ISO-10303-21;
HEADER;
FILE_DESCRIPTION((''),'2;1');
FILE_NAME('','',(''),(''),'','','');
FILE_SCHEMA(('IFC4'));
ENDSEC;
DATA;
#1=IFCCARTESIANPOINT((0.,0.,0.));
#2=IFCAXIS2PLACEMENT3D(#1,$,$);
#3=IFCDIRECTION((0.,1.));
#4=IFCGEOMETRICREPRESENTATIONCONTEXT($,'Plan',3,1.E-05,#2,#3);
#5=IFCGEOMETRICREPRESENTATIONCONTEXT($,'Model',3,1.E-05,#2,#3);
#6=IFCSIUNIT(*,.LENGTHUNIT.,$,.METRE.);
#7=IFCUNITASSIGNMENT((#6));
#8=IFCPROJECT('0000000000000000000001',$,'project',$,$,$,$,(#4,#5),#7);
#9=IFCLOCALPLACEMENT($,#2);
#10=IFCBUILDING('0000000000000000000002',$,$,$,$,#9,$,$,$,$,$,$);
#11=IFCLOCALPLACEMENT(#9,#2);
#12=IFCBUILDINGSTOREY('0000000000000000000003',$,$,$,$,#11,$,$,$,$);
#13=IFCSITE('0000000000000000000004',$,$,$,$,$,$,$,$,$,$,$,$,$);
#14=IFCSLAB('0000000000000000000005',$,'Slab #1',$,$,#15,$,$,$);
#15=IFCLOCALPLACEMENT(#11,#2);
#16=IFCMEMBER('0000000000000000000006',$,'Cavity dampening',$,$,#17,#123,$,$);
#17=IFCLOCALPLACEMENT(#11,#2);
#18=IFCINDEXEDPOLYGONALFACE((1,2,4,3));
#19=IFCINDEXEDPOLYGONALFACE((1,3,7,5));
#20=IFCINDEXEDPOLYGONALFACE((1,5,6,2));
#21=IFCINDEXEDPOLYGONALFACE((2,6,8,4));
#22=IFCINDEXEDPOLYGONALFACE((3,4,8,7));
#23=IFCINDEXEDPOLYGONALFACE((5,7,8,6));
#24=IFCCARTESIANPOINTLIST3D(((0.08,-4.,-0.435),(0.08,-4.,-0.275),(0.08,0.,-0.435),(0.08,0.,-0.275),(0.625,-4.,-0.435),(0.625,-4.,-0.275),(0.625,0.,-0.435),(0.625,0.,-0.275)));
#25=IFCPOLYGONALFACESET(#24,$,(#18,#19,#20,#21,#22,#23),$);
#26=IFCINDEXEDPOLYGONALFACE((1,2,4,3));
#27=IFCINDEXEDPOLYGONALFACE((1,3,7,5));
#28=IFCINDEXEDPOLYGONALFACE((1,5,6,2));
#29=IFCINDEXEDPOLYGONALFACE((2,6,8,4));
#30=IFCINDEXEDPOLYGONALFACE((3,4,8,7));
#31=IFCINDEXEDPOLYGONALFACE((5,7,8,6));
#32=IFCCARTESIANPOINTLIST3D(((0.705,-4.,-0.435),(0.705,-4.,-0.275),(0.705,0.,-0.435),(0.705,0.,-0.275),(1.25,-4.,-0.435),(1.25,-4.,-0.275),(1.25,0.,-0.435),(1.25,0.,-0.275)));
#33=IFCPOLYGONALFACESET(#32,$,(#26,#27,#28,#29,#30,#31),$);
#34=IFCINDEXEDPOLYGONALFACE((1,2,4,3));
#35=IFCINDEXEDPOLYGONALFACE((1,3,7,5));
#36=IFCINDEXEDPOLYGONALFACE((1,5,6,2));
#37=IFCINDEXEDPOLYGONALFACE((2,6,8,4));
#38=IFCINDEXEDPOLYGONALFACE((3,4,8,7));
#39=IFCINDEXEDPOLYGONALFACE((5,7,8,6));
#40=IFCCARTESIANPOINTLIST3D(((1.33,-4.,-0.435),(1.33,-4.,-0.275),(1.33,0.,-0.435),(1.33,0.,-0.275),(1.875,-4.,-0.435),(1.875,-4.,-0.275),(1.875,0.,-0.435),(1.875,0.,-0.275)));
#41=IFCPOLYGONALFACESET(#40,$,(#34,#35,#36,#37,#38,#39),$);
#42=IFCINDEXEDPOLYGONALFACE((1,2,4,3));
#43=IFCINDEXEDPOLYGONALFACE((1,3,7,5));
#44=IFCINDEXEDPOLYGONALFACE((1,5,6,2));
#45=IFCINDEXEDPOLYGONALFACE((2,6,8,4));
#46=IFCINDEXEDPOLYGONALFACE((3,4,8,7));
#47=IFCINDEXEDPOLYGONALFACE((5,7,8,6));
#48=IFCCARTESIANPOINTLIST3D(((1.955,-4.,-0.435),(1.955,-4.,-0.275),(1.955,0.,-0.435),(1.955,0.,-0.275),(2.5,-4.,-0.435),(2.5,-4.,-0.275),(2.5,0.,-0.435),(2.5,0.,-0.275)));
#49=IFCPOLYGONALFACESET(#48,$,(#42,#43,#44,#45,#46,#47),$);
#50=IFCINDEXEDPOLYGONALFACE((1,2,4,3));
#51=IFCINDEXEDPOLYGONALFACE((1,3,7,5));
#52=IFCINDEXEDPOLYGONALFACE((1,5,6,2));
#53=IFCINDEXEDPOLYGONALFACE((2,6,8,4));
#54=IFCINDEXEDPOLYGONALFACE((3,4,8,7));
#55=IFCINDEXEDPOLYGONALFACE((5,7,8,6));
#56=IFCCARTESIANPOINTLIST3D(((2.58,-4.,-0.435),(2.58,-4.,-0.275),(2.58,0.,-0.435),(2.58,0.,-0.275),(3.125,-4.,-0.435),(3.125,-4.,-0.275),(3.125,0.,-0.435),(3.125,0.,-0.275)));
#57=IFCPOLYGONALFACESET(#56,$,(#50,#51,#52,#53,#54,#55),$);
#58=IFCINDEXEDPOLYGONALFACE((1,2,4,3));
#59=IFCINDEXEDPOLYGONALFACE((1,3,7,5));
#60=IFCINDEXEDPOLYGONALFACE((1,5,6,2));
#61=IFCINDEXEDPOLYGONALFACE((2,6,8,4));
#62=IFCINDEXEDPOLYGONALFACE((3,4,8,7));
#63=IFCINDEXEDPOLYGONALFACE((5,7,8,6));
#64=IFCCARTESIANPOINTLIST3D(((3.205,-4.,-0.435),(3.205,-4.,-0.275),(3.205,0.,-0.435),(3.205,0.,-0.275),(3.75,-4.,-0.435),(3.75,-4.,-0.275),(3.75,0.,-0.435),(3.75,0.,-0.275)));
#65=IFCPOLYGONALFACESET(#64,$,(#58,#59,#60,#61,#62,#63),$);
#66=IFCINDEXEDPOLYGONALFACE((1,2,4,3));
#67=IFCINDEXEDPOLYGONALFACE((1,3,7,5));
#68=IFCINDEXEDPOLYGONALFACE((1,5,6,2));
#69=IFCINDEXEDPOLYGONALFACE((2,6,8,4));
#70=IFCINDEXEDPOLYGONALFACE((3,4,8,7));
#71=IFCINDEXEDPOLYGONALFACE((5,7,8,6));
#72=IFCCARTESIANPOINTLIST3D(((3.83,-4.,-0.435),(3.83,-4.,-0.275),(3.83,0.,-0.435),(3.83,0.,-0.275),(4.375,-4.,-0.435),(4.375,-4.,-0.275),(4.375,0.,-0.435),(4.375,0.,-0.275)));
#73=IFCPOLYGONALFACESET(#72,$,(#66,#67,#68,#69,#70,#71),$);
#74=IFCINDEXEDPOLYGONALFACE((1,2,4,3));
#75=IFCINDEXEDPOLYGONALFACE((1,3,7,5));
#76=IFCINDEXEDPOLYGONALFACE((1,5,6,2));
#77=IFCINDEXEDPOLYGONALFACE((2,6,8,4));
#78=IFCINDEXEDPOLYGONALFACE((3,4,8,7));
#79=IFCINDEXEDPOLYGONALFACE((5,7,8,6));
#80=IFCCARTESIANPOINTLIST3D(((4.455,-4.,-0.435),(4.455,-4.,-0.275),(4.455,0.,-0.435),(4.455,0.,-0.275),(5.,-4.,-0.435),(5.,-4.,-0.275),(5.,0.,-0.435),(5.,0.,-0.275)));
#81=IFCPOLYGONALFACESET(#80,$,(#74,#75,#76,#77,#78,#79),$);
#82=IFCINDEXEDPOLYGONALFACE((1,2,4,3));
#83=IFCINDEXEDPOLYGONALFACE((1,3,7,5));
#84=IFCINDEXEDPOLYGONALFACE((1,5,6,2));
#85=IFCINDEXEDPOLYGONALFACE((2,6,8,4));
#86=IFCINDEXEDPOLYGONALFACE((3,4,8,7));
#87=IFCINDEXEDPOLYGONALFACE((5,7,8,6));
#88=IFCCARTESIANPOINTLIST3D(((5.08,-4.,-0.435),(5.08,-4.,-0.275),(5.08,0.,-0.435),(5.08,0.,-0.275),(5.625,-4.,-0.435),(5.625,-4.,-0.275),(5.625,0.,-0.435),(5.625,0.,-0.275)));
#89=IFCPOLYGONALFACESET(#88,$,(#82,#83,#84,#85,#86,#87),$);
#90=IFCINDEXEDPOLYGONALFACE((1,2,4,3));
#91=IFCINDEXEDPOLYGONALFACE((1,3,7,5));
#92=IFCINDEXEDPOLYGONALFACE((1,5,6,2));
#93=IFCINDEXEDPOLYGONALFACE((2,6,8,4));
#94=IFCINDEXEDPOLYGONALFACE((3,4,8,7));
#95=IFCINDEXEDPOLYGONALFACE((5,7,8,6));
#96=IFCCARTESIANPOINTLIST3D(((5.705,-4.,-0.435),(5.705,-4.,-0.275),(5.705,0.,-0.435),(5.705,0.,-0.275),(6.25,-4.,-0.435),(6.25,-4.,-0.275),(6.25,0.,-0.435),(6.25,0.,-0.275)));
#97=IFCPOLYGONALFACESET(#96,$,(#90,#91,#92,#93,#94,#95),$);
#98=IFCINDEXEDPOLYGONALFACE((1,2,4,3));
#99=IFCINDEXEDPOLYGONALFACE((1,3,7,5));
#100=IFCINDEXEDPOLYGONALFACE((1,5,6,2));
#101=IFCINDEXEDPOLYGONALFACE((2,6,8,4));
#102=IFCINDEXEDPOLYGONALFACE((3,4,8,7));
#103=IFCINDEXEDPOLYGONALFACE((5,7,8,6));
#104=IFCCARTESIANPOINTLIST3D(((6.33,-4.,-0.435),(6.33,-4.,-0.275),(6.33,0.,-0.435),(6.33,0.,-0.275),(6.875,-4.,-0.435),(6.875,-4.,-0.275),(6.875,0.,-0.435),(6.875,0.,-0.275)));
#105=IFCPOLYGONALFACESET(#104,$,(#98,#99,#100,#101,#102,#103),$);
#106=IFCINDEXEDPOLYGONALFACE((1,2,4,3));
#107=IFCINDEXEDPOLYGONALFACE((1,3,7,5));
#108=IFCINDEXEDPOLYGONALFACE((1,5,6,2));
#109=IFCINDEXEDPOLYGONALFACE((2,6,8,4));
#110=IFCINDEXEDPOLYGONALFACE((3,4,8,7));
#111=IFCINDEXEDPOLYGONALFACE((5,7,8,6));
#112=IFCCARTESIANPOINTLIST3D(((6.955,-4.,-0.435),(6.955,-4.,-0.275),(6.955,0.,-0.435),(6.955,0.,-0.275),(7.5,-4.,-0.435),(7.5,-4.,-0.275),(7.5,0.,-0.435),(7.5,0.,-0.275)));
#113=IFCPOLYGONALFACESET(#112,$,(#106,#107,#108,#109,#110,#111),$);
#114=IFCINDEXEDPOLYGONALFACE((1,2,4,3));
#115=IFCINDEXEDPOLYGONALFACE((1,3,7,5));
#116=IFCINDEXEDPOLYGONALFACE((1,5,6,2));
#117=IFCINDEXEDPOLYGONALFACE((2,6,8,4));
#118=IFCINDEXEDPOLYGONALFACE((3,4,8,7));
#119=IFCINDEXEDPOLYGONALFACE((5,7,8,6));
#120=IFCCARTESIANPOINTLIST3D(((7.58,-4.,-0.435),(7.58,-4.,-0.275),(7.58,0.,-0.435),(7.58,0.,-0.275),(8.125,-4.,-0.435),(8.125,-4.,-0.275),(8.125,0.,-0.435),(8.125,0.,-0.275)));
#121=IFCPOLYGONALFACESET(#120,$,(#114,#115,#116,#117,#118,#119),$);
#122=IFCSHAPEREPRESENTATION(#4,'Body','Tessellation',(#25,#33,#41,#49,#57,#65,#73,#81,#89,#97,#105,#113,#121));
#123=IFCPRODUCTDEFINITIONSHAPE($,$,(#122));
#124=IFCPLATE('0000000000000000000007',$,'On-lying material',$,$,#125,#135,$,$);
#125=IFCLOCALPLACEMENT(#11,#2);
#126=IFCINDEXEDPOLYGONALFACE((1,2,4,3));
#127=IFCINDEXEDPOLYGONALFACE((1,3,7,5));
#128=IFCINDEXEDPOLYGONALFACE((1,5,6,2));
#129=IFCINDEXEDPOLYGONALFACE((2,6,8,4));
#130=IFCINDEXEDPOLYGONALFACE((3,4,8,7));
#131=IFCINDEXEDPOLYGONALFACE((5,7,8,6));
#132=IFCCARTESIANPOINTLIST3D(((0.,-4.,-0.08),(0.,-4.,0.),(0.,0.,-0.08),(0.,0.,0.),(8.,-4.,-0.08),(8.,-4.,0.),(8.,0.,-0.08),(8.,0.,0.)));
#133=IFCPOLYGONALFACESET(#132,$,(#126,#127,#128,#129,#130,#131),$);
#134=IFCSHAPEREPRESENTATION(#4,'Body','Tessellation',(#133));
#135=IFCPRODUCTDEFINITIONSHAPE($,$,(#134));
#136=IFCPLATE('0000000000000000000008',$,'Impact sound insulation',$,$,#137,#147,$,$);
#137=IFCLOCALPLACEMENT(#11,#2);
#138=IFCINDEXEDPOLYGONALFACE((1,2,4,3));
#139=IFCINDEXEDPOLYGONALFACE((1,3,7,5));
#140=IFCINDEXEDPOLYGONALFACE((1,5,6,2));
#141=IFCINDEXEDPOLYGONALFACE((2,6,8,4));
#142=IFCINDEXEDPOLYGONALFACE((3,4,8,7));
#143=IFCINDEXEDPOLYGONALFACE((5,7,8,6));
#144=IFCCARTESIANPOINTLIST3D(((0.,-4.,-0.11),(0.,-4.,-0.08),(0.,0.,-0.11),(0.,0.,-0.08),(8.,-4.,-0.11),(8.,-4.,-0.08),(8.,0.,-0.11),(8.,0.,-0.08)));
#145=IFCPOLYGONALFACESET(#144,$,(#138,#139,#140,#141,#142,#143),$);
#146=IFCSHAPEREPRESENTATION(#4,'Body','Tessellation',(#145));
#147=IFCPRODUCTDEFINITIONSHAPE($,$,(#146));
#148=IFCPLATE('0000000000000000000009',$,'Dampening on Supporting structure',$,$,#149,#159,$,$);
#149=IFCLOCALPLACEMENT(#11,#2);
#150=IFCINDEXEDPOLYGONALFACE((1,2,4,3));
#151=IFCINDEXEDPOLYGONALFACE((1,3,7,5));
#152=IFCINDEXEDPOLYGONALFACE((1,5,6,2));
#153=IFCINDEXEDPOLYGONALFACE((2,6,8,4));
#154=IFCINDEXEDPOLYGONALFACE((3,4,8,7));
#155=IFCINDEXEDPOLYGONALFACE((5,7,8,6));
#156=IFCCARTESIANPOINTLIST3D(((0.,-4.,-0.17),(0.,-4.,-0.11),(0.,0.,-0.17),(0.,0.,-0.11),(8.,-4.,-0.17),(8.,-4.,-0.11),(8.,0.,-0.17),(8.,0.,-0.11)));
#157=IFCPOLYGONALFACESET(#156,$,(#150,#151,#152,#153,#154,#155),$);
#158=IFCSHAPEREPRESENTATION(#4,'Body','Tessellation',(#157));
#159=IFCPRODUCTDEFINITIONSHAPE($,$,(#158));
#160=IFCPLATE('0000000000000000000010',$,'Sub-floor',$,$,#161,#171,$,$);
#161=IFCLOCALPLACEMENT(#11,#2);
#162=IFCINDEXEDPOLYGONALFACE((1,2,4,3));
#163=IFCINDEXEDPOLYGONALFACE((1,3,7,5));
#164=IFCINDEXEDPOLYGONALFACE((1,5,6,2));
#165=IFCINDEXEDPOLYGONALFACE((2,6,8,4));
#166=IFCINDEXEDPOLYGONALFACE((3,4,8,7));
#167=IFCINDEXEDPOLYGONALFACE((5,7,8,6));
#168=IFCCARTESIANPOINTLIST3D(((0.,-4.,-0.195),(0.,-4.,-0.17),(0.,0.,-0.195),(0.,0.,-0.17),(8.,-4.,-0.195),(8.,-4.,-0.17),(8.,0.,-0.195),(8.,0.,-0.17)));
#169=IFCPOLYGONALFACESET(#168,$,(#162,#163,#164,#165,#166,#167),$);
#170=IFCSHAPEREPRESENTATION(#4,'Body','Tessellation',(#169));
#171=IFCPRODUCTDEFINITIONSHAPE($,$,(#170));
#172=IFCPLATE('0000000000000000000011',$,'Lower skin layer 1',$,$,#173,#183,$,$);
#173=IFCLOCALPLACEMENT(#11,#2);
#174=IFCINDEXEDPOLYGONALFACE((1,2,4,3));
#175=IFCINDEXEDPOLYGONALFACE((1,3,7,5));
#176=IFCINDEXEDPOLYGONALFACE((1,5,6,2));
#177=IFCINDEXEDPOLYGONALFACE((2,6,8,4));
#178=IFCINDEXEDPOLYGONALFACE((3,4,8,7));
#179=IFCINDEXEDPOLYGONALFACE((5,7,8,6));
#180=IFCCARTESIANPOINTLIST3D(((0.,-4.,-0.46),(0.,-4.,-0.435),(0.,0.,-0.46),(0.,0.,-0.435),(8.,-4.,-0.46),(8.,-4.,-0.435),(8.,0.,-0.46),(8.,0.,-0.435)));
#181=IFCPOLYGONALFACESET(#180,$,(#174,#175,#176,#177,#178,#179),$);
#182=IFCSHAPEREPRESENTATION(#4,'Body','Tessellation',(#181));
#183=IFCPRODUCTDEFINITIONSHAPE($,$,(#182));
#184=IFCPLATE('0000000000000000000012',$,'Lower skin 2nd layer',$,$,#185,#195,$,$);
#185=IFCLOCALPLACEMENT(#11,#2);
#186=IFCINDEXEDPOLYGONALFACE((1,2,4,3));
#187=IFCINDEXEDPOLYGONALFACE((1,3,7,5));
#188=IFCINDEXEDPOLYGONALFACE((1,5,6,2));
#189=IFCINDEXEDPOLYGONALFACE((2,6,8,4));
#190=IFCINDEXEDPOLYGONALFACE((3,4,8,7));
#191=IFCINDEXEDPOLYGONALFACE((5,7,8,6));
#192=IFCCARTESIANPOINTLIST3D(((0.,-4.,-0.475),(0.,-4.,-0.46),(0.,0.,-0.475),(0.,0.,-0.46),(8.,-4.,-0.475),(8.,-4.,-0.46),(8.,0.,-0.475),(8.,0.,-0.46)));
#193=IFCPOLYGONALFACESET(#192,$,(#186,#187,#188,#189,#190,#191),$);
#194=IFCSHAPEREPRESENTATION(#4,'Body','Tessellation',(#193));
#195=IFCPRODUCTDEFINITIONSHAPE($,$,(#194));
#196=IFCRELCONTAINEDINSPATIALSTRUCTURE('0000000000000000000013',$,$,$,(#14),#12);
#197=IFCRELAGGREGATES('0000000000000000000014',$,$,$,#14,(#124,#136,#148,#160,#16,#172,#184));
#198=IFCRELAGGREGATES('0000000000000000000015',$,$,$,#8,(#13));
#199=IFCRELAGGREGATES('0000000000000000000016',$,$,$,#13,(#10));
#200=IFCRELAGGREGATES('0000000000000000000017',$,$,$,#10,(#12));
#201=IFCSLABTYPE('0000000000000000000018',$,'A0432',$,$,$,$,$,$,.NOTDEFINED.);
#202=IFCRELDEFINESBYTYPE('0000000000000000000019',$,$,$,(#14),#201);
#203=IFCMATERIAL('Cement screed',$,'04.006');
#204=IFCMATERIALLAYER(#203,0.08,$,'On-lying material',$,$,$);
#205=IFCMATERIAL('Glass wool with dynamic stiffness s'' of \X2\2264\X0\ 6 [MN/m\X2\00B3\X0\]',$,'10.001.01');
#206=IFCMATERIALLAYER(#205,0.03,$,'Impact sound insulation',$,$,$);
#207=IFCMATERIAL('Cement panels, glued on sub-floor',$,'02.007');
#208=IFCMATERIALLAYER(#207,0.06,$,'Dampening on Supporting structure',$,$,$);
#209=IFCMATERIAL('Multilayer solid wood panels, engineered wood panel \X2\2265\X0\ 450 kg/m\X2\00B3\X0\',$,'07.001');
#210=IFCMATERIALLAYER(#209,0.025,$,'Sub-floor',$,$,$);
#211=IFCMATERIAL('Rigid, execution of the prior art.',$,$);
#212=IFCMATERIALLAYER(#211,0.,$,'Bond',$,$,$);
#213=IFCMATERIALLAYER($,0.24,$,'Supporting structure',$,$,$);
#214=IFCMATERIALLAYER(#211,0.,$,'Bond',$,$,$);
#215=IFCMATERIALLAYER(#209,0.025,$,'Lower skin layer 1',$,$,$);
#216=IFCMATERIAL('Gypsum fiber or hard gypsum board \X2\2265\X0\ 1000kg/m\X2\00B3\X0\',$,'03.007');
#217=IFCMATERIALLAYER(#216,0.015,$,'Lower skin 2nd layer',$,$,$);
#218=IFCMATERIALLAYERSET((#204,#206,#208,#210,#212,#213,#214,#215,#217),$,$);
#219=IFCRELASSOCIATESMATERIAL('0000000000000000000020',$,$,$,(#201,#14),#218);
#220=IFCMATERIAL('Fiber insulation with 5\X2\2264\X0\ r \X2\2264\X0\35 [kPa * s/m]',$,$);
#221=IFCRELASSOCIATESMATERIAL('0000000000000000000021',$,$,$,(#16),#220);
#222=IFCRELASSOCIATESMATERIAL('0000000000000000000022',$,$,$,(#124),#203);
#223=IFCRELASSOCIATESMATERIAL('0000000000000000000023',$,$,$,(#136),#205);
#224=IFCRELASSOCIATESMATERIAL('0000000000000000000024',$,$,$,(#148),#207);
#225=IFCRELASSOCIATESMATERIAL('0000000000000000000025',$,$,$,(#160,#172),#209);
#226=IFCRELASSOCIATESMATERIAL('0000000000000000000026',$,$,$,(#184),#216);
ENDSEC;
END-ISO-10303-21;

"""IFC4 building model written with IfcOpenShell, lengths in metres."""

from ifc_helpers import new_model, si_unit, direction, frame, frame_2d, origin, origin_with_axes, place, context, project, spatial, rectangle, extrude, material, layer, layer_set, type_object, element, aggregate, save


model = new_model("IFC4")

# Units and contexts
plan_context = context("Plan", 3, precision=1e-05, world=origin(), true_north=direction((0.0, 1.0)))
model_context = context("Model", 3, precision=1e-05, world=origin(), true_north=direction((0.0, 1.0)))
ifc_project = project(units=[si_unit("LENGTHUNIT", "METRE")], contexts=[plan_context, model_context])

# Site, building, storey
site = spatial("IfcSite", under=ifc_project)
building_placement = place(None, origin())
building = spatial("IfcBuilding", under=site, at=building_placement)
storey_placement = place(building_placement, origin())
storey = spatial("IfcBuildingStorey", under=building, at=storey_placement)

# Slab, member, plates
ifc_material_1 = material(Name="Cement screed", Category="04.006")
ifc_layer_1 = layer(ifc_material_1, 0.08, Name="On-lying material")
ifc_material_2 = material(Name="Glass wool with dynamic stiffness s' of ≤ 6 [MN/m³]", Category="10.001.01")
ifc_layer_2 = layer(ifc_material_2, 0.03, Name="Impact sound insulation")
ifc_material_3 = material(Name="Cement panels, glued on sub-floor", Category="02.007")
ifc_layer_3 = layer(ifc_material_3, 0.06, Name="Dampening on Supporting structure")
ifc_material_4 = material(Name="Multilayer solid wood panels, engineered wood panel ≥ 450 kg/m³", Category="07.001")
ifc_layer_4 = layer(ifc_material_4, 0.025, Name="Sub-floor")
ifc_material_5 = material(Name="Rigid, execution of the prior art.")
ifc_layer_5 = layer(ifc_material_5, 0.0, Name="Bond")
ifc_layer_6 = layer(None, 0.24, Name="Supporting structure")
ifc_layer_7 = layer(ifc_material_5, 0.0, Name="Bond")
ifc_layer_8 = layer(ifc_material_4, 0.025, Name="Lower skin layer 1")
ifc_material_6 = material(Name="Gypsum fiber or hard gypsum board ≥ 1000kg/m³", Category="03.007")
ifc_layer_9 = layer(ifc_material_6, 0.015, Name="Lower skin 2nd layer")
ifc_layer_set = layer_set([ifc_layer_1, ifc_layer_2, ifc_layer_3, ifc_layer_4, ifc_layer_5, ifc_layer_6, ifc_layer_7, ifc_layer_8, ifc_layer_9])
slab_type = type_object("IfcSlabType", Name="A0432", PredefinedType="NOTDEFINED", material=ifc_layer_set)
slab_placement = place(None, frame((0.0, 0.0, 0.0), z_axis=(0.0, 0.0, -1.0), x_axis=(1.0, 0.0, 0.0)))
slab = element("IfcSlab", 1, at=slab_placement, inside=storey, type_object=slab_type, material=ifc_layer_set, Name="Slab #1")
ifc_material_7 = material(Name="Fiber insulation with 5≤ r ≤35 [kPa * s/m]")
member_1_placement = place(slab_placement, origin())
member_1 = element("IfcMember", 2, at=member_1_placement, material=ifc_material_7, Name="Cavity dampening", context=plan_context, shape_type="SweptSolid", body=[
    extrude(rectangle(XDim=0.545, YDim=0.16, at=frame_2d((0.2725, 0.08), x_axis=(1.0, 0.0))), frame((0.08, 4.0, 0.275), z_axis=(0.0, -1.0, 0.0), x_axis=(1.0, 0.0, 0.0)), (0.0, 0.0, 1.0), 4.0),
    extrude(rectangle(XDim=0.545, YDim=0.16, at=frame_2d((0.2725, 0.08), x_axis=(1.0, 0.0))), frame((0.705, 4.0, 0.275), z_axis=(0.0, -1.0, 0.0), x_axis=(1.0, 0.0, 0.0)), (0.0, 0.0, 1.0), 4.0),
    extrude(rectangle(XDim=0.545, YDim=0.16, at=frame_2d((0.2725, 0.08), x_axis=(1.0, 0.0))), frame((1.33, 4.0, 0.275), z_axis=(0.0, -1.0, 0.0), x_axis=(1.0, 0.0, 0.0)), (0.0, 0.0, 1.0), 4.0),
    extrude(rectangle(XDim=0.545, YDim=0.16, at=frame_2d((0.2725, 0.08), x_axis=(1.0, 0.0))), frame((1.955, 4.0, 0.275), z_axis=(0.0, -1.0, 0.0), x_axis=(1.0, 0.0, 0.0)), (0.0, 0.0, 1.0), 4.0),
    extrude(rectangle(XDim=0.545, YDim=0.16, at=frame_2d((0.2725, 0.08), x_axis=(1.0, 0.0))), frame((2.58, 4.0, 0.275), z_axis=(0.0, -1.0, 0.0), x_axis=(1.0, 0.0, 0.0)), (0.0, 0.0, 1.0), 4.0),
    extrude(rectangle(XDim=0.545, YDim=0.16, at=frame_2d((0.2725, 0.08), x_axis=(1.0, 0.0))), frame((3.205, 4.0, 0.275), z_axis=(0.0, -1.0, 0.0), x_axis=(1.0, 0.0, 0.0)), (0.0, 0.0, 1.0), 4.0),
    extrude(rectangle(XDim=0.545, YDim=0.16, at=frame_2d((0.2725, 0.08), x_axis=(1.0, 0.0))), frame((3.83, 4.0, 0.275), z_axis=(0.0, -1.0, 0.0), x_axis=(1.0, 0.0, 0.0)), (0.0, 0.0, 1.0), 4.0),
    extrude(rectangle(XDim=0.545, YDim=0.16, at=frame_2d((0.2725, 0.08), x_axis=(1.0, 0.0))), frame((4.455, 4.0, 0.275), z_axis=(0.0, -1.0, 0.0), x_axis=(1.0, 0.0, 0.0)), (0.0, 0.0, 1.0), 4.0),
    extrude(rectangle(XDim=0.545, YDim=0.16, at=frame_2d((0.2725, 0.08), x_axis=(1.0, 0.0))), frame((5.08, 4.0, 0.275), z_axis=(0.0, -1.0, 0.0), x_axis=(1.0, 0.0, 0.0)), (0.0, 0.0, 1.0), 4.0),
    extrude(rectangle(XDim=0.545, YDim=0.16, at=frame_2d((0.2725, 0.08), x_axis=(1.0, 0.0))), frame((5.705, 4.0, 0.275), z_axis=(0.0, -1.0, 0.0), x_axis=(1.0, 0.0, 0.0)), (0.0, 0.0, 1.0), 4.0),
    extrude(rectangle(XDim=0.545, YDim=0.16, at=frame_2d((0.2725, 0.08), x_axis=(1.0, 0.0))), frame((6.33, 4.0, 0.275), z_axis=(0.0, -1.0, 0.0), x_axis=(1.0, 0.0, 0.0)), (0.0, 0.0, 1.0), 4.0),
    extrude(rectangle(XDim=0.545, YDim=0.16, at=frame_2d((0.2725, 0.08), x_axis=(1.0, 0.0))), frame((6.955, 4.0, 0.275), z_axis=(0.0, -1.0, 0.0), x_axis=(1.0, 0.0, 0.0)), (0.0, 0.0, 1.0), 4.0),
    extrude(rectangle(XDim=0.545, YDim=0.16, at=frame_2d((0.2725, 0.08), x_axis=(1.0, 0.0))), frame((7.58, 4.0, 0.275), z_axis=(0.0, -1.0, 0.0), x_axis=(1.0, 0.0, 0.0)), (0.0, 0.0, 1.0), 4.0),
])
plate_1_placement = place(slab_placement, origin())
plate_1 = element("IfcPlate", 3, at=plate_1_placement, material=ifc_material_1, Name="On-lying material", context=plan_context, shape_type="SweptSolid", body=[
    extrude(rectangle(XDim=8.0, YDim=4.0, at=frame_2d((4.0, 2.0), x_axis=(1.0, 0.0))), origin_with_axes(), (0.0, 0.0, 1.0), 0.08),
])
plate_2_placement = place(slab_placement, origin())
plate_2 = element("IfcPlate", 4, at=plate_2_placement, material=ifc_material_2, Name="Impact sound insulation", context=plan_context, shape_type="SweptSolid", body=[
    extrude(rectangle(XDim=8.0, YDim=4.0, at=frame_2d((4.0, 2.0), x_axis=(1.0, 0.0))), frame((0.0, 0.0, 0.08), z_axis=(0.0, 0.0, 1.0), x_axis=(1.0, 0.0, 0.0)), (0.0, 0.0, 1.0), 0.03),
])
plate_3_placement = place(slab_placement, origin())
plate_3 = element("IfcPlate", 5, at=plate_3_placement, material=ifc_material_3, Name="Dampening on Supporting structure", context=plan_context, shape_type="SweptSolid", body=[
    extrude(rectangle(XDim=8.0, YDim=4.0, at=frame_2d((4.0, 2.0), x_axis=(1.0, 0.0))), frame((0.0, 0.0, 0.11), z_axis=(0.0, 0.0, 1.0), x_axis=(1.0, 0.0, 0.0)), (0.0, 0.0, 1.0), 0.06),
])
plate_4_placement = place(slab_placement, origin())
plate_4 = element("IfcPlate", 6, at=plate_4_placement, material=ifc_material_4, Name="Sub-floor", context=plan_context, shape_type="SweptSolid", body=[
    extrude(rectangle(XDim=8.0, YDim=4.0, at=frame_2d((4.0, 2.0), x_axis=(1.0, 0.0))), frame((0.0, 0.0, 0.17), z_axis=(0.0, 0.0, 1.0), x_axis=(1.0, 0.0, 0.0)), (0.0, 0.0, 1.0), 0.025),
])
plate_5_placement = place(slab_placement, origin())
plate_5 = element("IfcPlate", 7, at=plate_5_placement, material=ifc_material_4, Name="Lower skin layer 1", context=plan_context, shape_type="SweptSolid", body=[
    extrude(rectangle(XDim=8.0, YDim=4.0, at=frame_2d((4.0, 2.0), x_axis=(1.0, 0.0))), frame((0.0, 0.0, 0.435), z_axis=(0.0, 0.0, 1.0), x_axis=(1.0, 0.0, 0.0)), (0.0, 0.0, 1.0), 0.025),
])
plate_6_placement = place(slab_placement, origin())
plate_6 = element("IfcPlate", 8, at=plate_6_placement, material=ifc_material_6, Name="Lower skin 2nd layer", context=plan_context, shape_type="SweptSolid", body=[
    extrude(rectangle(XDim=8.0, YDim=4.0, at=frame_2d((4.0, 2.0), x_axis=(1.0, 0.0))), frame((0.0, 0.0, 0.46), z_axis=(0.0, 0.0, 1.0), x_axis=(1.0, 0.0, 0.0)), (0.0, 0.0, 1.0), 0.015),
])
aggregate(slab, [plate_1, plate_2, plate_3, plate_4, member_1, plate_5, plate_6])

save(model, "model.ifc")
